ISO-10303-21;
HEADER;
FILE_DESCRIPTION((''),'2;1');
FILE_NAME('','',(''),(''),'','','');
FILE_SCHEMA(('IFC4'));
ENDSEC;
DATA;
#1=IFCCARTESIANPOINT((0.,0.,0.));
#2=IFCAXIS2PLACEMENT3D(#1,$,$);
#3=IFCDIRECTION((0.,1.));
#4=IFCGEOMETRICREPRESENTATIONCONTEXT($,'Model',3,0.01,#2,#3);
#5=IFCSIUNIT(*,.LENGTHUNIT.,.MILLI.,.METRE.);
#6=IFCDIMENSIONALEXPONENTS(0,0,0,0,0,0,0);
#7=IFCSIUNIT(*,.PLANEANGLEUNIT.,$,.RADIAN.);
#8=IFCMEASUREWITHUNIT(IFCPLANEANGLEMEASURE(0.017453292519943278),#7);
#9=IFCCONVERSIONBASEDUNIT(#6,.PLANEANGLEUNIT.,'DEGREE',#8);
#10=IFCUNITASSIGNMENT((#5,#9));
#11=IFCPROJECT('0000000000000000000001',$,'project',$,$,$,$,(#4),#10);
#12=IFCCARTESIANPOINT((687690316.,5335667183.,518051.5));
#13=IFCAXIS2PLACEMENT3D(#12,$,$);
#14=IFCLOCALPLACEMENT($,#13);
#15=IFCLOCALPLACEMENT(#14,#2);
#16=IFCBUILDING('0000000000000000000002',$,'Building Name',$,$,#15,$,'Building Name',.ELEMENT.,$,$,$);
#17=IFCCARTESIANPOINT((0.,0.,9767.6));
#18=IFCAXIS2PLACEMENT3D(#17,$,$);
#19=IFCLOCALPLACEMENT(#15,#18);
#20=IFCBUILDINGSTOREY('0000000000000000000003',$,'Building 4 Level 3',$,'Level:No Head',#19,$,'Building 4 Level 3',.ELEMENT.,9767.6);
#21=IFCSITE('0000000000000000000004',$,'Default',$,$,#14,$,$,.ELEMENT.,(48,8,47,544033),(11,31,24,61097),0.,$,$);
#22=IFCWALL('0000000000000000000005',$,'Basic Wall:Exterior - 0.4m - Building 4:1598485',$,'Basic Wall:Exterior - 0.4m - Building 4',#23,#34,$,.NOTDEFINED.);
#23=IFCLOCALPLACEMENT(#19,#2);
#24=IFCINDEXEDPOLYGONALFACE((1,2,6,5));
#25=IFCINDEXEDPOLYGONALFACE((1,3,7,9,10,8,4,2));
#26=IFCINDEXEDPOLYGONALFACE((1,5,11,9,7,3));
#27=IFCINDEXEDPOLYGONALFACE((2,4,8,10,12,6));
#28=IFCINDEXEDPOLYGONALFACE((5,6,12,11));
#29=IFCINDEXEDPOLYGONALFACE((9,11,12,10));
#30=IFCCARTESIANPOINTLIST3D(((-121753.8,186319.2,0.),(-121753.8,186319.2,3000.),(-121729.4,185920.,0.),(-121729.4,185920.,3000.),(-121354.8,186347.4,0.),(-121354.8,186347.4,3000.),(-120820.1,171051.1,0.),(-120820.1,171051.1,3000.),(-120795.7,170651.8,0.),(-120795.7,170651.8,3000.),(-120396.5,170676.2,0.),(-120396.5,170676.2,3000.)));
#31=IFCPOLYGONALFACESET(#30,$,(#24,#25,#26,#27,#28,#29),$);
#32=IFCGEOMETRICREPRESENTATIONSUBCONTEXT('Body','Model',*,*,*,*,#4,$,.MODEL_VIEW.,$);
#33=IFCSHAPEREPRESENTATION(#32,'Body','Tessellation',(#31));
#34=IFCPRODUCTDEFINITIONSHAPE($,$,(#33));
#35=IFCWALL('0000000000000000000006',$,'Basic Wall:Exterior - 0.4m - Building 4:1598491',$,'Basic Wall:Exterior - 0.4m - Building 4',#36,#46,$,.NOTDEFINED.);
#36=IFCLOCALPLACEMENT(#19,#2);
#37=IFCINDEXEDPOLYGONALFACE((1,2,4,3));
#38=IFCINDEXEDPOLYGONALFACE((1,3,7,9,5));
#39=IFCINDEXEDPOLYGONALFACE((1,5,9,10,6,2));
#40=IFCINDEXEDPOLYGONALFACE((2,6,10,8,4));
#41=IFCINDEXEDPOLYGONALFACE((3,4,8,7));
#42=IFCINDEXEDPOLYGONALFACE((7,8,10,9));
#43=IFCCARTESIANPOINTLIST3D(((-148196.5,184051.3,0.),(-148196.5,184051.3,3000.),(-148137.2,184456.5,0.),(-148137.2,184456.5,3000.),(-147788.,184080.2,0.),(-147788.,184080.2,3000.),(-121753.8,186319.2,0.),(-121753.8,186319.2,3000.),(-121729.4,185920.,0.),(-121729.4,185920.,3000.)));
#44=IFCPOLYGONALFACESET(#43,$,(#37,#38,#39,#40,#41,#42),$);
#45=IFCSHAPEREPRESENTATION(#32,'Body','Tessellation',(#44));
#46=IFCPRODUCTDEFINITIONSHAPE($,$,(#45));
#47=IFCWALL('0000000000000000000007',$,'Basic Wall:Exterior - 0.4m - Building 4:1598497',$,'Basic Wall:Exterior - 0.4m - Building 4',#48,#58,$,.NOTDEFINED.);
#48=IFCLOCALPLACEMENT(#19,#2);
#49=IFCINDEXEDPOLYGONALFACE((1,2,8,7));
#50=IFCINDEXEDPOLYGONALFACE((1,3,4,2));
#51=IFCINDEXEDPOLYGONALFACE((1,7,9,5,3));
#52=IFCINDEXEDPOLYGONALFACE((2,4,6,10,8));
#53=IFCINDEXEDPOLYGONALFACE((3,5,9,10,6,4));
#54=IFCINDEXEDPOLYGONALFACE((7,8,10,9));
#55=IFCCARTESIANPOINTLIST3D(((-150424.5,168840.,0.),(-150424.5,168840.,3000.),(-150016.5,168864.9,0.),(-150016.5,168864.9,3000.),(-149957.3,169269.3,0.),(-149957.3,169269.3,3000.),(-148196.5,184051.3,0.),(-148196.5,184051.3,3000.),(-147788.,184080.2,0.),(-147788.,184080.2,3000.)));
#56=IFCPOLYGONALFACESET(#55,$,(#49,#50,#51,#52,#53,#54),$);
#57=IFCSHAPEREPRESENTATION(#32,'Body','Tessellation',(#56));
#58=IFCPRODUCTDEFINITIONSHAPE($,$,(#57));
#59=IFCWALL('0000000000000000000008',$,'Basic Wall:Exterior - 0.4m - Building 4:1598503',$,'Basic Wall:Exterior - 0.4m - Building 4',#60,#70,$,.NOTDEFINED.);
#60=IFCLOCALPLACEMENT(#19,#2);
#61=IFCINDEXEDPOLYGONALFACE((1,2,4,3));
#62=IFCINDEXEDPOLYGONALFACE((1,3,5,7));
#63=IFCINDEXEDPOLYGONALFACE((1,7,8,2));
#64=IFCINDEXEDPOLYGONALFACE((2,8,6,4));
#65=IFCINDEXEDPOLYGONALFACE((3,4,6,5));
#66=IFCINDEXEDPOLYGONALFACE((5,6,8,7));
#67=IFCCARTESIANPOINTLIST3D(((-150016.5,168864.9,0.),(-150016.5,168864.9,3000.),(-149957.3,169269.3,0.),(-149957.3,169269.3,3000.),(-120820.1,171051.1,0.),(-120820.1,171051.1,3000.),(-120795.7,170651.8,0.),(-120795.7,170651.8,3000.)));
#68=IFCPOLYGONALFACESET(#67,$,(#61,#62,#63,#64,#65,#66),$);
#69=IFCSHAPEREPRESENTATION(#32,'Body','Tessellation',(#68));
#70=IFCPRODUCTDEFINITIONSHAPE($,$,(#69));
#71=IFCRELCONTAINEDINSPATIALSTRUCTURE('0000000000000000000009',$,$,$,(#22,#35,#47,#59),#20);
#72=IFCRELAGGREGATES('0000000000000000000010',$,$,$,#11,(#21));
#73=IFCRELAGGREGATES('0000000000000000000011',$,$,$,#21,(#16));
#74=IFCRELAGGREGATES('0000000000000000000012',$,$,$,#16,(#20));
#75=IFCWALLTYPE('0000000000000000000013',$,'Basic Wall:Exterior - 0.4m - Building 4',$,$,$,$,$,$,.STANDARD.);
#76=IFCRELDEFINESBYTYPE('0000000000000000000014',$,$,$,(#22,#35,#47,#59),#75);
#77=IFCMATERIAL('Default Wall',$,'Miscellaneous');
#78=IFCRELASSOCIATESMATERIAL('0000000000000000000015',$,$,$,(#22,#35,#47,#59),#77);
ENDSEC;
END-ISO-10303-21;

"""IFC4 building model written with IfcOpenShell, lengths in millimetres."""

from ifc_helpers import new_model, entity, si_unit, converted_unit, direction, frame, origin, place, context, subcontext, project, spatial, indexed_curve, outline, extrude, material, type_object, element, save


model = new_model("IFC4")

# Units and contexts
model_context = context("Model", 3, precision=0.01, world=origin(), true_north=direction((0.0, 1.0)))
body_context = subcontext(model_context, "Body", "Model", "MODEL_VIEW")
ifc_project = project(units=[si_unit("LENGTHUNIT", "METRE", prefix="MILLI"), converted_unit("PLANEANGLEUNIT", "DEGREE", entity("IfcPlaneAngleMeasure", 0.017453292519943278), si_unit("PLANEANGLEUNIT", "RADIAN"), dimensions=[0, 0, 0, 0, 0, 0, 0])], contexts=[model_context])

# Site, building, storey
site_placement = place(None, frame((687690316.0, 5335667183.0, 518051.5)))
site = spatial("IfcSite", under=ifc_project, at=site_placement, Name="Default", CompositionType="ELEMENT", RefLatitude=(48, 8, 47, 544033), RefLongitude=(11, 31, 24, 61097), RefElevation=0.0)
building_placement = place(site_placement, origin())
building = spatial("IfcBuilding", under=site, at=building_placement, Name="Building Name", LongName="Building Name", CompositionType="ELEMENT")
storey_placement = place(building_placement, frame((0.0, 0.0, 9767.6)))
storey = spatial("IfcBuildingStorey", under=building, at=storey_placement, Name="Building 4 Level 3", ObjectType="Level:No Head", LongName="Building 4 Level 3", CompositionType="ELEMENT", Elevation=9767.6)

# Walls
ifc_material_1 = material(Name="Default Wall", Category="Miscellaneous")
wall_type = type_object("IfcWallType", Name="Basic Wall:Exterior - 0.4m - Building 4", PredefinedType="STANDARD")
wall_1_placement = place(storey_placement, frame((-120596.1, 170664.0, 0.0), z_axis=(0.0, 0.0, 1.0), x_axis=(-0.061037, 0.998136, 0.0)))
element("IfcWall", 1, at=wall_1_placement, inside=storey, type_object=wall_type, material=ifc_material_1, Name="Basic Wall:Exterior - 0.4m - Building 4:1598485", ObjectType="Basic Wall:Exterior - 0.4m - Building 4", PredefinedType="NOTDEFINED", context=body_context, shape_type="SweptSolid", body=[
    extrude(outline(indexed_curve([(15700.4, -200.0), (15696.7, 200.0), (15296.7, 200.0), (400.0, 200.0), (0.0, 200.0), (0.0, -200.0), (15700.4, -200.0)], self_intersect=False)), origin(), (0.0, 0.0, 1.0), 3000.0),
])
wall_2_placement = place(storey_placement, frame((-121739.7, 186119.7, 0.0), z_axis=(0.0, 0.0, 1.0), x_axis=(-0.997517, -0.070427, 0.0)))
element("IfcWall", 2, at=wall_2_placement, inside=storey, type_object=wall_type, material=ifc_material_1, Name="Basic Wall:Exterior - 0.4m - Building 4:1598491", ObjectType="Basic Wall:Exterior - 0.4m - Building 4", PredefinedType="NOTDEFINED", context=body_context, shape_type="SweptSolid", body=[
    extrude(outline(indexed_curve([(26449.1, -200.0), (26536.8, 200.0), (26127.3, 200.0), (3.8, 200.0), (0.0, -200.0), (26449.1, -200.0)], self_intersect=False)), origin(), (0.0, 0.0, 1.0), 3000.0),
])
wall_3_placement = place(storey_placement, frame((-147985.9, 184109.1, 0.0), z_axis=(0.0, 0.0, 1.0), x_axis=(-0.144921, -0.989443, 0.0)))
element("IfcWall", 3, at=wall_3_placement, inside=storey, type_object=wall_type, material=ifc_material_1, Name="Basic Wall:Exterior - 0.4m - Building 4:1598497", ObjectType="Basic Wall:Exterior - 0.4m - Building 4", PredefinedType="NOTDEFINED", context=body_context, shape_type="SweptSolid", body=[
    extrude(outline(indexed_curve([(15461.4, -200.0), (15377.6, 200.0), (14968.9, 200.0), (0.0, 200.0), (87.7, -200.0), (15461.4, -200.0)], self_intersect=False)), origin(), (0.0, 0.0, 1.0), 3000.0),
])
wall_4_placement = place(storey_placement, frame((-150028.8, 169064.6, 0.0), z_axis=(0.0, 0.0, 1.0), x_axis=(0.998136, 0.061037, 0.0)))
element("IfcWall", 4, at=wall_4_placement, inside=storey, type_object=wall_type, material=ifc_material_1, Name="Basic Wall:Exterior - 0.4m - Building 4:1598503", ObjectType="Basic Wall:Exterior - 0.4m - Building 4", PredefinedType="NOTDEFINED", context=body_context, shape_type="SweptSolid", body=[
    extrude(outline(indexed_curve([(29275.4, -200.0), (29275.4, 200.0), (83.8, 200.0), (0.0, -200.0), (29275.4, -200.0)], self_intersect=False)), origin(), (0.0, 0.0, 1.0), 3000.0),
])

save(model, "model.ifc")
